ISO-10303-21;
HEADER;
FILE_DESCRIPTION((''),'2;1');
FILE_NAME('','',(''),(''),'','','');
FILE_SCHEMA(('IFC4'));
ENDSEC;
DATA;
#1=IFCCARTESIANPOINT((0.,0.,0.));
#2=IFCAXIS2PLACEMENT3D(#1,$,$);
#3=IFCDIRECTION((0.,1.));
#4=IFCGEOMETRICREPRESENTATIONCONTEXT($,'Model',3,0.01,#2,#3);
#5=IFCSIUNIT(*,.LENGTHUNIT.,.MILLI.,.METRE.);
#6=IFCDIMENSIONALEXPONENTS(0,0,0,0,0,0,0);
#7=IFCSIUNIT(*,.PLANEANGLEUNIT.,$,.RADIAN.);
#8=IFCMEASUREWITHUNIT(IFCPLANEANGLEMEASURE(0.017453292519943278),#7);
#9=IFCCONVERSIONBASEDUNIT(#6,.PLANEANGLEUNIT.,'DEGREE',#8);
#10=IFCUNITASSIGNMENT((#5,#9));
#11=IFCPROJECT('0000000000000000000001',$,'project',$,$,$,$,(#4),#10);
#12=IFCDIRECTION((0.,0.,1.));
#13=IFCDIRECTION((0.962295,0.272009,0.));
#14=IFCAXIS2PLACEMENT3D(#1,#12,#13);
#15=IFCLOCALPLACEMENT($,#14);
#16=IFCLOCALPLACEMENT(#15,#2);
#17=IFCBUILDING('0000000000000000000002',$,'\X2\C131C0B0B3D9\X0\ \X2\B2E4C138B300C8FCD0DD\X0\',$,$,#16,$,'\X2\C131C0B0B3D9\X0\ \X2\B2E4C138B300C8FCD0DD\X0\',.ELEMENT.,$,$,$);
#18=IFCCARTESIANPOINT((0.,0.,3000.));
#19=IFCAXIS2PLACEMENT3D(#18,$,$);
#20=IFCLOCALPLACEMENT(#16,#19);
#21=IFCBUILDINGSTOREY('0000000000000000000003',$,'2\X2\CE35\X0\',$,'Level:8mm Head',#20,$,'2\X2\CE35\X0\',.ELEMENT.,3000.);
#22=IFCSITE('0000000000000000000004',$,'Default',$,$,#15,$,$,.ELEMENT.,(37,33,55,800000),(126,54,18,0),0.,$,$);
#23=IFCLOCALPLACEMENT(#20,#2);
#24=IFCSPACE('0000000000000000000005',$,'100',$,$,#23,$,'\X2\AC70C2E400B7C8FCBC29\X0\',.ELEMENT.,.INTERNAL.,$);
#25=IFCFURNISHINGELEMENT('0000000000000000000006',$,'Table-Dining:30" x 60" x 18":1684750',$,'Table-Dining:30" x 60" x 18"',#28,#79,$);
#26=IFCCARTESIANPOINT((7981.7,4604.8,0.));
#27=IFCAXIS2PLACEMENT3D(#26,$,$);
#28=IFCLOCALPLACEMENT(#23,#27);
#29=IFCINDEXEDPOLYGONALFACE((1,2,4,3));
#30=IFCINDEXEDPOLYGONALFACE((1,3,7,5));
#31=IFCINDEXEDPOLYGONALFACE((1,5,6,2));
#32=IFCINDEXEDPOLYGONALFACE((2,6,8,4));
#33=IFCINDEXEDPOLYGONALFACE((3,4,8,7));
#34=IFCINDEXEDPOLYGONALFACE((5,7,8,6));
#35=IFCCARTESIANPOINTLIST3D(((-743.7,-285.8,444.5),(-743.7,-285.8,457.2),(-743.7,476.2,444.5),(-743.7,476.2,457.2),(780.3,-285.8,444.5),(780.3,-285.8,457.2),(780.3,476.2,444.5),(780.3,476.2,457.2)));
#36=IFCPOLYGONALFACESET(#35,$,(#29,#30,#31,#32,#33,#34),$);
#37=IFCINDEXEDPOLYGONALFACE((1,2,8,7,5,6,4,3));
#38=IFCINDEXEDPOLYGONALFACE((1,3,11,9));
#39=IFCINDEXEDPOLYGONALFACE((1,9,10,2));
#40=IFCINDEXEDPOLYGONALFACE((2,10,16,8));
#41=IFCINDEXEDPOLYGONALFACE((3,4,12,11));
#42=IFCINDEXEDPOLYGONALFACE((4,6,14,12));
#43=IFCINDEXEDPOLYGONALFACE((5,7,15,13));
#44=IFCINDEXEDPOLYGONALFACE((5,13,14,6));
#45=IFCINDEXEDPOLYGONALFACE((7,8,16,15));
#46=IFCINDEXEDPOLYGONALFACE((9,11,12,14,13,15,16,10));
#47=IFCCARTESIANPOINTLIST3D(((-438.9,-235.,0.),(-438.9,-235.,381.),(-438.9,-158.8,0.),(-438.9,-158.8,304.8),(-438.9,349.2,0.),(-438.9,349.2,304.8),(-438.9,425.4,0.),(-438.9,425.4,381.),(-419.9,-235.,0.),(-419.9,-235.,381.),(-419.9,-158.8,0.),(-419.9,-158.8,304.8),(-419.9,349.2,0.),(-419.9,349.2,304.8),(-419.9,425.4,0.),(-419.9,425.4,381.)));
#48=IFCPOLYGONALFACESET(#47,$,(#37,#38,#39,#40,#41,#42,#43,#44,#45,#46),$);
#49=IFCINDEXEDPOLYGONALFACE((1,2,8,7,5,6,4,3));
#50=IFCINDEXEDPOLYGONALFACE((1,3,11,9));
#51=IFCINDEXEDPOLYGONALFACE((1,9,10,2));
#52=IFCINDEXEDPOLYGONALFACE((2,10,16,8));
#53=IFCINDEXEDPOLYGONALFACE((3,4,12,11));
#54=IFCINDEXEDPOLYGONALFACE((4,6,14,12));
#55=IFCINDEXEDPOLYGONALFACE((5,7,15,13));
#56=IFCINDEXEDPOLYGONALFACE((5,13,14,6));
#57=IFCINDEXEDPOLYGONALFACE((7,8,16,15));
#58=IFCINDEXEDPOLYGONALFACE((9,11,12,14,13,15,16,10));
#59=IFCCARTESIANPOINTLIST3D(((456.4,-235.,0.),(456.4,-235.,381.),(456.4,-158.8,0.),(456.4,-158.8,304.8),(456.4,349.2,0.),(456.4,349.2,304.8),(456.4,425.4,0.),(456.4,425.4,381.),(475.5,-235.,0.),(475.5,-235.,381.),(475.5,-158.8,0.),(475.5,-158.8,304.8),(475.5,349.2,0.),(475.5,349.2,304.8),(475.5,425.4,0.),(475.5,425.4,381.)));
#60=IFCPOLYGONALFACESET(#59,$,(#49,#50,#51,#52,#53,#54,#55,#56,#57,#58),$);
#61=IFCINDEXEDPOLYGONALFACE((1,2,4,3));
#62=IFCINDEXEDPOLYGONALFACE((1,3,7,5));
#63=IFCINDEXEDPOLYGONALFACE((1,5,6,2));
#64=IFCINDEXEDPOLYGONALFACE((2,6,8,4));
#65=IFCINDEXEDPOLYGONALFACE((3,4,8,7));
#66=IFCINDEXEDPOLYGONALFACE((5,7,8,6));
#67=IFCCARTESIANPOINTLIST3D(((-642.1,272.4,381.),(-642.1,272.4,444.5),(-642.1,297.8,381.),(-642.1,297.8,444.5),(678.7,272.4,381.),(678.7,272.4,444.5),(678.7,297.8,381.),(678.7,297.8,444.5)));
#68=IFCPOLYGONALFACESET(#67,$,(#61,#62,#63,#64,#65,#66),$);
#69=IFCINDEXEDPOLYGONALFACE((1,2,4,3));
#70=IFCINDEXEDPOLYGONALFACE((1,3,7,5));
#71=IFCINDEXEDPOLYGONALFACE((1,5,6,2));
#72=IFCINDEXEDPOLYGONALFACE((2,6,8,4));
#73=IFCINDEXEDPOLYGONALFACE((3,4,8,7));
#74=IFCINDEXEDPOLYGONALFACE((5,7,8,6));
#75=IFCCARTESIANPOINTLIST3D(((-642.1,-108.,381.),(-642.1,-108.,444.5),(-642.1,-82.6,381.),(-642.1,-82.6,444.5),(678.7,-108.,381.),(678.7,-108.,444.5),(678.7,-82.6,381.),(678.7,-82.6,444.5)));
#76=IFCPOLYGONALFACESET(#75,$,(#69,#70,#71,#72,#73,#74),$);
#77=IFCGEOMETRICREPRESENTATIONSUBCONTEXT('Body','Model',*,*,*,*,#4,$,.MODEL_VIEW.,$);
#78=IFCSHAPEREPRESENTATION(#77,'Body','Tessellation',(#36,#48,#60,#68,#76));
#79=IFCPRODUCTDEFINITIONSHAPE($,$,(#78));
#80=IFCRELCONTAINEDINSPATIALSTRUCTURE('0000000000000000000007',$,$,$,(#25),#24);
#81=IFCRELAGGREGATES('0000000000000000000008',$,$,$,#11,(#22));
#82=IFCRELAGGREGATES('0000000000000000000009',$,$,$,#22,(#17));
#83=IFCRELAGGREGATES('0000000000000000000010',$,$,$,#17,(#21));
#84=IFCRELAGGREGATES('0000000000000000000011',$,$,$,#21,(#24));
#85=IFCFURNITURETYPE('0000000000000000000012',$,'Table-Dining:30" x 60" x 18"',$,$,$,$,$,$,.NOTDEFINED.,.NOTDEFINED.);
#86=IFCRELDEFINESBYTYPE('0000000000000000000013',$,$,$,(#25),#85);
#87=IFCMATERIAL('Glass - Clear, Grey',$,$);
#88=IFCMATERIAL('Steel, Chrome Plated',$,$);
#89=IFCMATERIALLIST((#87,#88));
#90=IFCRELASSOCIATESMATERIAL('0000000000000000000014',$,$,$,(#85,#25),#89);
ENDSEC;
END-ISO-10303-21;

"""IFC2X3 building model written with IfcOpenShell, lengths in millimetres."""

from ifc_helpers import new_model, entity, si_unit, converted_unit, direction, frame, frame_2d, origin, origin_2d_with_axis, place, context, subcontext, project, spatial, polyline, rectangle, outline, extrude, source, transform, mapped, material, material_list, type_object, type_shapes, element, save


model = new_model("IFC2X3")

# Units and contexts
model_context = context("Model", 3, precision=0.01, world=origin(), true_north=direction((0.0, 1.0)))
body_context = subcontext(model_context, "Body", "Model", "MODEL_VIEW")
ifc_project = project(units=[si_unit("LENGTHUNIT", "METRE", prefix="MILLI"), converted_unit("PLANEANGLEUNIT", "DEGREE", entity("IfcPlaneAngleMeasure", 0.017453292519943278), si_unit("PLANEANGLEUNIT", "RADIAN"), dimensions=[0, 0, 0, 0, 0, 0, 0])], contexts=[model_context])

# Site, building, storey
site_placement = place(None, frame((0.0, 0.0, 0.0), z_axis=(0.0, 0.0, 1.0), x_axis=(0.962295, 0.272009, 0.0)))
site = spatial("IfcSite", under=ifc_project, at=site_placement, Name="Default", CompositionType="ELEMENT", RefLatitude=(37, 33, 55, 800000), RefLongitude=(126, 54, 18, 0), RefElevation=0.0)
building_placement = place(site_placement, origin())
building = spatial("IfcBuilding", under=site, at=building_placement, Name="성산동 다세대주택", LongName="성산동 다세대주택", CompositionType="ELEMENT")
storey_placement = place(building_placement, frame((0.0, 0.0, 3000.0)))
storey = spatial("IfcBuildingStorey", under=building, at=storey_placement, Name="2층", ObjectType="Level:8mm Head", LongName="2층", CompositionType="ELEMENT", Elevation=3000.0)

# Shared definitions
space_1_placement = place(storey_placement, origin())
space_1 = spatial("IfcSpace", under=storey, at=space_1_placement, Name="100", LongName="거실·주방", CompositionType="ELEMENT", InteriorOrExteriorSpace="INTERNAL")

# Furnishing element
ifc_material_1 = material(Name="Glass - Clear, Grey")
ifc_material_2 = material(Name="Steel, Chrome Plated")
ifc_material_list_1 = material_list([ifc_material_1, ifc_material_2])
furniture_type_1 = type_object("IfcFurnitureType", Name="Table-Dining:30\" x 60\" x 18\"", AssemblyPlace="NOTDEFINED", material=ifc_material_list_1)
shared_shape_1 = source(origin(), body_context, "Body", "SweptSolid", [
    extrude(rectangle(XDim=1524.0, YDim=762.0, at=frame_2d((0.0, 0.0), x_axis=(1.0, 0.0))), frame((18.3, 95.2, 444.5), z_axis=(0.0, 0.0, 1.0), x_axis=(-1.0, 0.0, 0.0)), (0.0, 0.0, 1.0), 12.7),
    extrude(outline(polyline([(-330.2, -209.5), (330.2, -209.5), (330.2, 171.4), (254.0, 171.4), (254.0, -133.3), (-254.0, -133.3), (-254.0, 171.4), (-330.2, 171.4), (-330.2, -209.5)])), frame((-438.9, 95.2, 171.4), z_axis=(1.0, 0.0, 0.0), x_axis=(0.0, -1.0, 0.0)), (0.0, 0.0, 1.0), 19.1),
    extrude(outline(polyline([(-171.4, -330.2), (209.5, -330.2), (209.5, 330.2), (-171.4, 330.2), (-171.4, 254.0), (133.3, 254.0), (133.3, -254.0), (-171.4, -254.0), (-171.4, -330.2)])), frame((456.4, 95.2, 171.4), z_axis=(1.0, 0.0, 0.0), x_axis=(0.0, 0.0, 1.0)), (0.0, 0.0, 1.0), 19.1),
    extrude(rectangle(XDim=1320.8, YDim=25.4, at=frame_2d((0.0, 0.0), x_axis=(1.0, 0.0))), frame((18.3, 285.1, 381.0), z_axis=(0.0, 0.0, 1.0), x_axis=(-1.0, 0.0, 0.0)), (0.0, 0.0, 1.0), 63.5),
    extrude(rectangle(XDim=1320.8, YDim=25.4, at=origin_2d_with_axis()), frame((18.3, -95.3, 381.0), z_axis=(0.0, 0.0, 1.0), x_axis=(-1.0, 0.0, 0.0)), (0.0, 0.0, 1.0), 63.5),
])
type_shapes(furniture_type_1, [shared_shape_1])
furnishing_1_placement = place(space_1_placement, frame((7981.7, 4604.8, 0.0)))
element("IfcFurnishingElement", 1, at=furnishing_1_placement, inside=space_1, type_object=furniture_type_1, material=ifc_material_list_1, Name="Table-Dining:30\" x 60\" x 18\":1684750", ObjectType="Table-Dining:30\" x 60\" x 18\"", context=body_context, shape_type="MappedRepresentation", body=[
    mapped(shared_shape_1, transform((0.0, 0.0, 0.0), scale=1.0)),
])

save(model, "model.ifc")
